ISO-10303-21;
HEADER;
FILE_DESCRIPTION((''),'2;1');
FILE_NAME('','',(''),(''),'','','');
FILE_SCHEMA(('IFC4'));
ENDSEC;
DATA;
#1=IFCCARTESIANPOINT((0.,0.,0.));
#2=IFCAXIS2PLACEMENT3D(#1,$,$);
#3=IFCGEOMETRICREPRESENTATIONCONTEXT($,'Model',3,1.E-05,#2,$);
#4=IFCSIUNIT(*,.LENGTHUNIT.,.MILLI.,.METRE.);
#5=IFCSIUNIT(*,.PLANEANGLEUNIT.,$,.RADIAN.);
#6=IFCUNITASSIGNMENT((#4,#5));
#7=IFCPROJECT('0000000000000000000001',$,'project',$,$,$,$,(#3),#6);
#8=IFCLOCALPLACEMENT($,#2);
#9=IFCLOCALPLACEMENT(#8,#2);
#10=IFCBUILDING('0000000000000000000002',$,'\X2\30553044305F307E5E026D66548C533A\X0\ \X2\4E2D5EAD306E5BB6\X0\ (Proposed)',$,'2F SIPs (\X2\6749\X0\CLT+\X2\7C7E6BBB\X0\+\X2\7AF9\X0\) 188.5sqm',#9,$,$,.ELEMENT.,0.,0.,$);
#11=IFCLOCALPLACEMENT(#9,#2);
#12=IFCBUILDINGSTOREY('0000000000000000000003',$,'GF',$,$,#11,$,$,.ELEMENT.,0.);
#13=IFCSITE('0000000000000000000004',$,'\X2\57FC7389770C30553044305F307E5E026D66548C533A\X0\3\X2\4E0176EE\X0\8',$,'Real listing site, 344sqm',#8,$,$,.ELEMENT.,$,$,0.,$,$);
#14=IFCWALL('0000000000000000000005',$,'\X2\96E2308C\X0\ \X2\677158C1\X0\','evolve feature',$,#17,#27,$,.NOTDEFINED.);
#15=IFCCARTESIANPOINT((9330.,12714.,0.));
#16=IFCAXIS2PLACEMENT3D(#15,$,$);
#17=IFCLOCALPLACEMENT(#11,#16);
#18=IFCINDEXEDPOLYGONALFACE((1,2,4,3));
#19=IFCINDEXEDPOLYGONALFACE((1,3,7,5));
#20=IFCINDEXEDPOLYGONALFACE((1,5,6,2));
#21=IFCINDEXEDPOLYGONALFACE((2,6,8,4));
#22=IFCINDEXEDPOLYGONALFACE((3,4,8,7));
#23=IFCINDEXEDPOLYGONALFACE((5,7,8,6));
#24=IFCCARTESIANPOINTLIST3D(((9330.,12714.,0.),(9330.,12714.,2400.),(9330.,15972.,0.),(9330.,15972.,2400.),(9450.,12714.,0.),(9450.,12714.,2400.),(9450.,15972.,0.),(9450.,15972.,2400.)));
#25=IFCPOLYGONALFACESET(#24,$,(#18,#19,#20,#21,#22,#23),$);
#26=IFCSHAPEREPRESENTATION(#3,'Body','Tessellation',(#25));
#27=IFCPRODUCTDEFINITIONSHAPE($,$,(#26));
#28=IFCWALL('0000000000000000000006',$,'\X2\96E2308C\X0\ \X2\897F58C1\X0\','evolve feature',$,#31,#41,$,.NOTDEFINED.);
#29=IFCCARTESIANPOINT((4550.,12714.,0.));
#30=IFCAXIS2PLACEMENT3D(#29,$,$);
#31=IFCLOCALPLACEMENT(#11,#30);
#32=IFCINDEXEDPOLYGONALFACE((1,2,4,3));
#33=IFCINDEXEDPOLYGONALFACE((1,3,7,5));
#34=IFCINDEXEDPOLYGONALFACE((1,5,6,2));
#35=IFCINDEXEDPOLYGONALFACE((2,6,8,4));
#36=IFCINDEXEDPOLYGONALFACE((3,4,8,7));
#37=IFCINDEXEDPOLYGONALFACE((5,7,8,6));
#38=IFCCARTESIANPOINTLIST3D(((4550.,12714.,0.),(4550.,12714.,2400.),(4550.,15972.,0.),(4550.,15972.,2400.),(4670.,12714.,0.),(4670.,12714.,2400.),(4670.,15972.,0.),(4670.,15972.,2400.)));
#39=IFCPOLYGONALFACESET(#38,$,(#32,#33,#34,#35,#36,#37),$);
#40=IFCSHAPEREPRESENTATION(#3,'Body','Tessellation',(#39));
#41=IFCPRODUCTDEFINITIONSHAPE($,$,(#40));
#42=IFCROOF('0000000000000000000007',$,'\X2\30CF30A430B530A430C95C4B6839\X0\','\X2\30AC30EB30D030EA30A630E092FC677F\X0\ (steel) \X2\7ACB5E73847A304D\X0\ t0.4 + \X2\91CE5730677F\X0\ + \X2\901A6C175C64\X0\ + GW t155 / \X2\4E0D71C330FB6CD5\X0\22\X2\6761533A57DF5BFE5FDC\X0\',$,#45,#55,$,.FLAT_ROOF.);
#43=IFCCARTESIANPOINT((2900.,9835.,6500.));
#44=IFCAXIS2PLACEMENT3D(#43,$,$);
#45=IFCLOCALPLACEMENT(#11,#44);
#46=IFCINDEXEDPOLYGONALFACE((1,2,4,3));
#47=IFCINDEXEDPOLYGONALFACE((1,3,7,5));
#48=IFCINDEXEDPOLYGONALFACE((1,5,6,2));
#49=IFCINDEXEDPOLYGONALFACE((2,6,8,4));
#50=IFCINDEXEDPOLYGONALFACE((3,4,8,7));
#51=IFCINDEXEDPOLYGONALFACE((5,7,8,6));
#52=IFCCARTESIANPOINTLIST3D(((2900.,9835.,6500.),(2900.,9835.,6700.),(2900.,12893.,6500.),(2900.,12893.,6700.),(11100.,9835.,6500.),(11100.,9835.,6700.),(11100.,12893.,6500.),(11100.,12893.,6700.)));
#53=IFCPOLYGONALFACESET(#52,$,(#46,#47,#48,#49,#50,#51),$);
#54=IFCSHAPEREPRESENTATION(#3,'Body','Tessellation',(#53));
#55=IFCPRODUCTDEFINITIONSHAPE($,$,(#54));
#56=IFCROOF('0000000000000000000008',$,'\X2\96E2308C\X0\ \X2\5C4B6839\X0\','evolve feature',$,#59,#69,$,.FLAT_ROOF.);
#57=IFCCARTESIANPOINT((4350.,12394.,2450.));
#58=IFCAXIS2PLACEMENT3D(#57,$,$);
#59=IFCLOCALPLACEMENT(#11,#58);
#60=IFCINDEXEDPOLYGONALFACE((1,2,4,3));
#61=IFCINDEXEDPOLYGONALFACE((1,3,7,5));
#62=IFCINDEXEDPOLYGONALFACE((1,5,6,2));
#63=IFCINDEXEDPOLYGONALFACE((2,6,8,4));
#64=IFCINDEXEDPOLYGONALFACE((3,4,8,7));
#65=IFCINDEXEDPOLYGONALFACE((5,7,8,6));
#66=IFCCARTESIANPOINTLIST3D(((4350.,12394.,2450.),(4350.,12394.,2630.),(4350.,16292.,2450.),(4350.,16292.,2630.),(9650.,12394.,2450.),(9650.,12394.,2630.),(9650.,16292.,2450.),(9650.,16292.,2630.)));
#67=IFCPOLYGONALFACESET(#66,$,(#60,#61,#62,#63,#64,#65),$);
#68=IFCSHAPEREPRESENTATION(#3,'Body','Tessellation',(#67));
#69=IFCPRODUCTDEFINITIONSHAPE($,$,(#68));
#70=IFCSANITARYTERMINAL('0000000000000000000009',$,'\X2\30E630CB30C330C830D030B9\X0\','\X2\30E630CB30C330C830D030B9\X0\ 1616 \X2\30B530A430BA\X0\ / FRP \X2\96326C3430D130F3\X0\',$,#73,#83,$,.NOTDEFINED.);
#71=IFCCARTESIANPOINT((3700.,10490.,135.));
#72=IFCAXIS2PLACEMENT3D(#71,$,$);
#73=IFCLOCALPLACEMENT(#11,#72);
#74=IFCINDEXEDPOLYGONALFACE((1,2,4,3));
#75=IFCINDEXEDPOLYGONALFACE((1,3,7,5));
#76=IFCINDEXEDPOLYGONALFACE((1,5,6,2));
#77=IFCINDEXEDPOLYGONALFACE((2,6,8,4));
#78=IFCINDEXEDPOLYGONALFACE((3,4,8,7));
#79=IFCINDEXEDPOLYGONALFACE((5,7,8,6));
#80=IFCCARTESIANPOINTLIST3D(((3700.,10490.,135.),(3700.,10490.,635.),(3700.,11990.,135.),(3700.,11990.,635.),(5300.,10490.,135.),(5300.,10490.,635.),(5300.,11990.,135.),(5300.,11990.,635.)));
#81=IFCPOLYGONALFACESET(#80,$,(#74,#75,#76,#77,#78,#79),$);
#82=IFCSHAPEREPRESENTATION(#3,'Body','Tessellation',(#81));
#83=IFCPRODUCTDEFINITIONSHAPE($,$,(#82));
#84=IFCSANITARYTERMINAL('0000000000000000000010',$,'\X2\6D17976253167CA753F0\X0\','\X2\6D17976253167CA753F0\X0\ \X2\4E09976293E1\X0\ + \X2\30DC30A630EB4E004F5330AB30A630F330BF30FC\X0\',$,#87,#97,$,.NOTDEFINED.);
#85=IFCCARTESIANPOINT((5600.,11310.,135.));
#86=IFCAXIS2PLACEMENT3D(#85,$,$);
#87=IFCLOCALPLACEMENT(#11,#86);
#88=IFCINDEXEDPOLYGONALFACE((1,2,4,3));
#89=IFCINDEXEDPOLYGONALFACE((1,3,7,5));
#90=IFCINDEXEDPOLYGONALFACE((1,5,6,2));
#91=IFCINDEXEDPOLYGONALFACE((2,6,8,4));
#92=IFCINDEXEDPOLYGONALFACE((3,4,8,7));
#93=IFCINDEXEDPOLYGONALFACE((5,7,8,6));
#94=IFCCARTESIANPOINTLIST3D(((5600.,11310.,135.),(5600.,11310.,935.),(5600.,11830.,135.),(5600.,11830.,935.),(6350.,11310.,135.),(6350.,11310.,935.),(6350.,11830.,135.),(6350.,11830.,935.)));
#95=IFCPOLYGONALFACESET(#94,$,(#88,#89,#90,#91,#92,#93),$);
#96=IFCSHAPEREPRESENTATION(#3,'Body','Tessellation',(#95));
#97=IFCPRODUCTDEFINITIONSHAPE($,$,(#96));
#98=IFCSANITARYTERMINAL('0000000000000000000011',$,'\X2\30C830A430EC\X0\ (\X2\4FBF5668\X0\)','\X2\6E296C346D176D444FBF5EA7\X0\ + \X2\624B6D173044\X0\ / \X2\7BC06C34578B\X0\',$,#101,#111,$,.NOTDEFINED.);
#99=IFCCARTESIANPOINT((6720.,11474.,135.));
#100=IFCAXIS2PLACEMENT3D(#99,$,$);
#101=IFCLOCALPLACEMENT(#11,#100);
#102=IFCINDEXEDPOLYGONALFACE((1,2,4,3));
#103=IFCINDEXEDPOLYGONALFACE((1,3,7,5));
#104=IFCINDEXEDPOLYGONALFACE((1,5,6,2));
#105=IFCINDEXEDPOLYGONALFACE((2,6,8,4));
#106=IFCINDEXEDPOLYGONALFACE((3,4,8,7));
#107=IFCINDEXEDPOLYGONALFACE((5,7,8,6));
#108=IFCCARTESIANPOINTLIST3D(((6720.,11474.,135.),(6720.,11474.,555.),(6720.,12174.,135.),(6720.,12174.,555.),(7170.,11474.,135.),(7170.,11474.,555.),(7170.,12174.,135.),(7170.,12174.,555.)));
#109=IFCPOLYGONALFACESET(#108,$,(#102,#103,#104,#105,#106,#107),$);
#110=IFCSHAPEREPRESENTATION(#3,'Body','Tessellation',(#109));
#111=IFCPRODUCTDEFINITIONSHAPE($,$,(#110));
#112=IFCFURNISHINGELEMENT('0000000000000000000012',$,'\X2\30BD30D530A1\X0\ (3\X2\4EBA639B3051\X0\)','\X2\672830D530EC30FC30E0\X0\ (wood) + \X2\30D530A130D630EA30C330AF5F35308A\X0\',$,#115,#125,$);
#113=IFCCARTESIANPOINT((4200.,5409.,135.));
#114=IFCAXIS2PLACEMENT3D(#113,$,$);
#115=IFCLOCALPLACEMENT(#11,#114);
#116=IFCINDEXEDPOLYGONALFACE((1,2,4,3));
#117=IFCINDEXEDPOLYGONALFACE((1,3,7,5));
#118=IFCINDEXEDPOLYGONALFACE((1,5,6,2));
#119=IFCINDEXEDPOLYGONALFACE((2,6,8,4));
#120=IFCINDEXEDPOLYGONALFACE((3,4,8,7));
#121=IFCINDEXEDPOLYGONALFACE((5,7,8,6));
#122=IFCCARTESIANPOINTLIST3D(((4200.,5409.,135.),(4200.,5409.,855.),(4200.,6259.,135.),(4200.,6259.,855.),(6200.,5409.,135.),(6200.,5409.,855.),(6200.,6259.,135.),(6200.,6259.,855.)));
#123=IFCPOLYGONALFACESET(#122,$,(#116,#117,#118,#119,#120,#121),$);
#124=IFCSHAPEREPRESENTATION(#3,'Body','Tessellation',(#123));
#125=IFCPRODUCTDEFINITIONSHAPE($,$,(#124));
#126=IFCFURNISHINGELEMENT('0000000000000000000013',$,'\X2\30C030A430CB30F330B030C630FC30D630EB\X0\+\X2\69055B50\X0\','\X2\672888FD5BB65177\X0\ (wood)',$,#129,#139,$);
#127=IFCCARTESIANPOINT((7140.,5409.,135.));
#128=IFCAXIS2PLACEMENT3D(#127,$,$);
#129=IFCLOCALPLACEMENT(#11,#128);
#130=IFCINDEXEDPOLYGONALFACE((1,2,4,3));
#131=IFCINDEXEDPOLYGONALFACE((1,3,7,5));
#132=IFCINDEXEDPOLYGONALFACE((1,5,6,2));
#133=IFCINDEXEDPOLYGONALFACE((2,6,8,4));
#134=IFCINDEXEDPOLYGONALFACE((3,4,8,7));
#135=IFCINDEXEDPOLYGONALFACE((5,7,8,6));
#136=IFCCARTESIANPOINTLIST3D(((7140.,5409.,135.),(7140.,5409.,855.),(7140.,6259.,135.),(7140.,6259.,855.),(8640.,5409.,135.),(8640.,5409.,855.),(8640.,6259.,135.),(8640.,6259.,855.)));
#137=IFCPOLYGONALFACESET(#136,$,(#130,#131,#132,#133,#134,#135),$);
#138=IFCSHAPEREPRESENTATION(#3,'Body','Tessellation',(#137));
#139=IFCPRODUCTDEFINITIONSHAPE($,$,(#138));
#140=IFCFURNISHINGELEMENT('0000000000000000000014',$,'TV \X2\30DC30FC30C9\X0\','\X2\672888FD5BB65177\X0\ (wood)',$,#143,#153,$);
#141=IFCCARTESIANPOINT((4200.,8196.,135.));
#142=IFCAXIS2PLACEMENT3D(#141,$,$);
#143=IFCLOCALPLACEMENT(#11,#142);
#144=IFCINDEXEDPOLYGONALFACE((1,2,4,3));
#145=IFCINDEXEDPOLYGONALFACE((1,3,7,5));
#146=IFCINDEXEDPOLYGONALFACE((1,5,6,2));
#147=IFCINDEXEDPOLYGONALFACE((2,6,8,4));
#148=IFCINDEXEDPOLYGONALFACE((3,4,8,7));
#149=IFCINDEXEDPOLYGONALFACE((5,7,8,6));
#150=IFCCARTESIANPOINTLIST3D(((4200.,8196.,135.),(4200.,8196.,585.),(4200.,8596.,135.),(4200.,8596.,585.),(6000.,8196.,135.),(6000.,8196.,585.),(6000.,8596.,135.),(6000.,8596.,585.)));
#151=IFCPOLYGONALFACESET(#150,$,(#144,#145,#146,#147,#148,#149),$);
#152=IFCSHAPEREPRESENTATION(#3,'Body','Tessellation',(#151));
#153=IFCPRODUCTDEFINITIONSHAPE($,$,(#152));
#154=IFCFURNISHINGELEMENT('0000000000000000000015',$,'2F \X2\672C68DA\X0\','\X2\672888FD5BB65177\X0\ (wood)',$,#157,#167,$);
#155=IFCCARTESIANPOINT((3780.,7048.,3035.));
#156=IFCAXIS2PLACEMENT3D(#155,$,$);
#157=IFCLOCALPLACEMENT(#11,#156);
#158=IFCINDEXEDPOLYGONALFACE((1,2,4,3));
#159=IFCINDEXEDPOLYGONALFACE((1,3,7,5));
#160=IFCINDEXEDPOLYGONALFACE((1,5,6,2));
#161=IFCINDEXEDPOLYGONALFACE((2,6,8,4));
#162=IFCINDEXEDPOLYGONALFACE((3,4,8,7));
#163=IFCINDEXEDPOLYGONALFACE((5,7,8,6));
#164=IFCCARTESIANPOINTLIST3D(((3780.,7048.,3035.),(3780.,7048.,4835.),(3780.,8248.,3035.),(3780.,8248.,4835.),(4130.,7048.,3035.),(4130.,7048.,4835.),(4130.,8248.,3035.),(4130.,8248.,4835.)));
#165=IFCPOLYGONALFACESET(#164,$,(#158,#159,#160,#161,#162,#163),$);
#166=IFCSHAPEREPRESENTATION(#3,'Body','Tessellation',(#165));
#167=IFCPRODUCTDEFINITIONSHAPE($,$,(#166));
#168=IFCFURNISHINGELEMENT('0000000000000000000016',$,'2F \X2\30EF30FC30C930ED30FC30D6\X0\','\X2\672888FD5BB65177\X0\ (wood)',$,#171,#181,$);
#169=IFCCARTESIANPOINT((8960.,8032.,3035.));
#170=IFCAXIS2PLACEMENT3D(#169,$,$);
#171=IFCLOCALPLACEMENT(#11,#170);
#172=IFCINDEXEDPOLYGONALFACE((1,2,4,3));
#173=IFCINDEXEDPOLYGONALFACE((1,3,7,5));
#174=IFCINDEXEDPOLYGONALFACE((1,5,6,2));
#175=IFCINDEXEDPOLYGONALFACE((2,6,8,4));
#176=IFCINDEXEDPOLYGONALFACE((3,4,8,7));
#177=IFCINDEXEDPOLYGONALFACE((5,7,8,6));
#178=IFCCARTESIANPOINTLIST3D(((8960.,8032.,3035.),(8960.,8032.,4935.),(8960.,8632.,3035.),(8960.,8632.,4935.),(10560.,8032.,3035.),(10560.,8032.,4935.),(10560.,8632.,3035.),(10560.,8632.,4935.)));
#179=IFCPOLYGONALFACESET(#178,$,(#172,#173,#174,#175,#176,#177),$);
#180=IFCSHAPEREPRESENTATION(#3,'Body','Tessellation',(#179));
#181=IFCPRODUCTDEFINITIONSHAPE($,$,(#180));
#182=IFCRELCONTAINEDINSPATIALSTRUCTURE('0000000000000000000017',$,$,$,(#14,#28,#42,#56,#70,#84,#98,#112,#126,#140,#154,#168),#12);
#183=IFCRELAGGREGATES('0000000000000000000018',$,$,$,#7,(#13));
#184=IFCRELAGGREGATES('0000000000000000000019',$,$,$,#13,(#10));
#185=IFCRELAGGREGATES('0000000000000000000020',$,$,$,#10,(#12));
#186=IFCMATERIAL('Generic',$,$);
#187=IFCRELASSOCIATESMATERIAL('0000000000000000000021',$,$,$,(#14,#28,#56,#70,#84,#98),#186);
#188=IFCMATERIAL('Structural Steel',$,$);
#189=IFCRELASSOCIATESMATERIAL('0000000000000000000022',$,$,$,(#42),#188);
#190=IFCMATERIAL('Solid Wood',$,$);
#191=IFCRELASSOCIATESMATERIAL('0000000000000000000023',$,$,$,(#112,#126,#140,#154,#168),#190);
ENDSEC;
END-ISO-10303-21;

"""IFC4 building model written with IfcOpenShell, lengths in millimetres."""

from ifc_helpers import new_model, si_unit, frame, frame_2d, origin, place, context, project, spatial, rectangle, extrude, material, element, save


model = new_model("IFC4")

# Units and contexts
model_context = context("Model", 3, precision=1e-05, world=origin())
ifc_project = project(units=[si_unit("LENGTHUNIT", "METRE", prefix="MILLI"), si_unit("PLANEANGLEUNIT", "RADIAN")], contexts=[model_context])

# Site, building, storey
site_placement = place(None, origin())
site = spatial("IfcSite", under=ifc_project, at=site_placement, Name="埼玉県さいたま市浦和区3丁目8", ObjectType="Real listing site, 344sqm", CompositionType="ELEMENT", RefElevation=0.0)
building_placement = place(site_placement, origin())
building = spatial("IfcBuilding", under=site, at=building_placement, Name="さいたま市浦和区 中庭の家 (Proposed)", ObjectType="2F SIPs (杉CLT+籾殻+竹) 188.5sqm", CompositionType="ELEMENT", ElevationOfRefHeight=0.0, ElevationOfTerrain=0.0)
storey_placement = place(building_placement, origin())
storey = spatial("IfcBuildingStorey", under=building, at=storey_placement, Name="GF", CompositionType="ELEMENT", Elevation=0.0)

# Shared definitions
ifc_material_1 = material(Name="Generic")

# Shared definitions
ifc_material_2 = material(Name="Solid Wood")

# Walls
wall_1_placement = place(storey_placement, frame((9330.0, 12714.0, 0.0)))
element("IfcWall", 1, at=wall_1_placement, inside=storey, material=ifc_material_1, Name="離れ 東壁", Description="evolve feature", PredefinedType="NOTDEFINED", context=model_context, shape_type="SweptSolid", body=[
    extrude(rectangle(XDim=120.0, YDim=3258.0, at=frame_2d((60.0, 1629.0))), frame((9330.0, 12714.0, 0.0)), (0.0, 0.0, 1.0), 2400.0),
])
wall_2_placement = place(storey_placement, frame((4550.0, 12714.0, 0.0)))
element("IfcWall", 2, at=wall_2_placement, inside=storey, material=ifc_material_1, Name="離れ 西壁", Description="evolve feature", PredefinedType="NOTDEFINED", context=model_context, shape_type="SweptSolid", body=[
    extrude(rectangle(XDim=120.0, YDim=3258.0, at=frame_2d((60.0, 1629.0))), frame((4550.0, 12714.0, 0.0)), (0.0, 0.0, 1.0), 2400.0),
])

# Roofs
ifc_material_3 = material(Name="Structural Steel")
roof_1_placement = place(storey_placement, frame((2900.0, 9835.0, 6500.0)))
element("IfcRoof", 3, at=roof_1_placement, inside=storey, material=ifc_material_3, Name="ハイサイド屋根", Description="ガルバリウム鋼板 (steel) 立平葺き t0.4 + 野地板 + 通気層 + GW t155 / 不燃・法22条区域対応", PredefinedType="FLAT_ROOF", context=model_context, shape_type="SweptSolid", body=[
    extrude(rectangle(XDim=8200.0, YDim=3058.0, at=frame_2d((4100.0, 1529.0))), frame((2900.0, 9835.0, 6500.0)), (0.0, 0.0, 1.0), 200.0),
])
roof_2_placement = place(storey_placement, frame((4350.0, 12394.0, 2450.0)))
element("IfcRoof", 4, at=roof_2_placement, inside=storey, material=ifc_material_1, Name="離れ 屋根", Description="evolve feature", PredefinedType="FLAT_ROOF", context=model_context, shape_type="SweptSolid", body=[
    extrude(rectangle(XDim=5300.0, YDim=3898.0, at=frame_2d((2650.0, 1949.0))), frame((4350.0, 12394.0, 2450.0)), (0.0, 0.0, 1.0), 180.0),
])

# Sanitary terminals
sanitary_terminal_1_placement = place(storey_placement, frame((3700.0, 10490.0, 135.0)))
element("IfcSanitaryTerminal", 5, at=sanitary_terminal_1_placement, inside=storey, material=ifc_material_1, Name="ユニットバス", Description="ユニットバス 1616 サイズ / FRP 防水パン", PredefinedType="NOTDEFINED", context=model_context, shape_type="SweptSolid", body=[
    extrude(rectangle(XDim=1600.0, YDim=1500.0, at=frame_2d((800.0, 750.0))), frame((3700.0, 10490.0, 135.0)), (0.0, 0.0, 1.0), 500.0),
])
sanitary_terminal_2_placement = place(storey_placement, frame((5600.0, 11310.0, 135.0)))
element("IfcSanitaryTerminal", 6, at=sanitary_terminal_2_placement, inside=storey, material=ifc_material_1, Name="洗面化粧台", Description="洗面化粧台 三面鏡 + ボウル一体カウンター", PredefinedType="NOTDEFINED", context=model_context, shape_type="SweptSolid", body=[
    extrude(rectangle(XDim=750.0, YDim=520.0, at=frame_2d((375.0, 260.0))), frame((5600.0, 11310.0, 135.0)), (0.0, 0.0, 1.0), 800.0),
])
sanitary_terminal_3_placement = place(storey_placement, frame((6720.0, 11474.0, 135.0)))
element("IfcSanitaryTerminal", 7, at=sanitary_terminal_3_placement, inside=storey, material=ifc_material_1, Name="トイレ (便器)", Description="温水洗浄便座 + 手洗い / 節水型", PredefinedType="NOTDEFINED", context=model_context, shape_type="SweptSolid", body=[
    extrude(rectangle(XDim=450.0, YDim=700.0, at=frame_2d((225.0, 350.0))), frame((6720.0, 11474.0, 135.0)), (0.0, 0.0, 1.0), 420.0),
])

# Furnishing elements
furnishing_1_placement = place(storey_placement, frame((4200.0, 5409.0, 135.0)))
element("IfcFurnishingElement", 8, at=furnishing_1_placement, inside=storey, material=ifc_material_2, Name="ソファ (3人掛け)", Description="木フレーム (wood) + ファブリック張り", context=model_context, shape_type="SweptSolid", body=[
    extrude(rectangle(XDim=2000.0, YDim=850.0, at=frame_2d((1000.0, 425.0))), frame((4200.0, 5409.0, 135.0)), (0.0, 0.0, 1.0), 720.0),
])
furnishing_2_placement = place(storey_placement, frame((7140.0, 5409.0, 135.0)))
element("IfcFurnishingElement", 9, at=furnishing_2_placement, inside=storey, material=ifc_material_2, Name="ダイニングテーブル+椅子", Description="木製家具 (wood)", context=model_context, shape_type="SweptSolid", body=[
    extrude(rectangle(XDim=1500.0, YDim=850.0, at=frame_2d((750.0, 425.0))), frame((7140.0, 5409.0, 135.0)), (0.0, 0.0, 1.0), 720.0),
])
furnishing_3_placement = place(storey_placement, frame((4200.0, 8196.0, 135.0)))
element("IfcFurnishingElement", 10, at=furnishing_3_placement, inside=storey, material=ifc_material_2, Name="TV ボード", Description="木製家具 (wood)", context=model_context, shape_type="SweptSolid", body=[
    extrude(rectangle(XDim=1800.0, YDim=400.0, at=frame_2d((900.0, 200.0))), frame((4200.0, 8196.0, 135.0)), (0.0, 0.0, 1.0), 450.0),
])
furnishing_4_placement = place(storey_placement, frame((3780.0, 7048.0, 3035.0)))
element("IfcFurnishingElement", 11, at=furnishing_4_placement, inside=storey, material=ifc_material_2, Name="2F 本棚", Description="木製家具 (wood)", context=model_context, shape_type="SweptSolid", body=[
    extrude(rectangle(XDim=350.0, YDim=1200.0, at=frame_2d((175.0, 600.0))), frame((3780.0, 7048.0, 3035.0)), (0.0, 0.0, 1.0), 1800.0),
])
furnishing_5_placement = place(storey_placement, frame((8960.0, 8032.0, 3035.0)))
element("IfcFurnishingElement", 12, at=furnishing_5_placement, inside=storey, material=ifc_material_2, Name="2F ワードローブ", Description="木製家具 (wood)", context=model_context, shape_type="SweptSolid", body=[
    extrude(rectangle(XDim=1600.0, YDim=600.0, at=frame_2d((800.0, 300.0))), frame((8960.0, 8032.0, 3035.0)), (0.0, 0.0, 1.0), 1900.0),
])

save(model, "model.ifc")
